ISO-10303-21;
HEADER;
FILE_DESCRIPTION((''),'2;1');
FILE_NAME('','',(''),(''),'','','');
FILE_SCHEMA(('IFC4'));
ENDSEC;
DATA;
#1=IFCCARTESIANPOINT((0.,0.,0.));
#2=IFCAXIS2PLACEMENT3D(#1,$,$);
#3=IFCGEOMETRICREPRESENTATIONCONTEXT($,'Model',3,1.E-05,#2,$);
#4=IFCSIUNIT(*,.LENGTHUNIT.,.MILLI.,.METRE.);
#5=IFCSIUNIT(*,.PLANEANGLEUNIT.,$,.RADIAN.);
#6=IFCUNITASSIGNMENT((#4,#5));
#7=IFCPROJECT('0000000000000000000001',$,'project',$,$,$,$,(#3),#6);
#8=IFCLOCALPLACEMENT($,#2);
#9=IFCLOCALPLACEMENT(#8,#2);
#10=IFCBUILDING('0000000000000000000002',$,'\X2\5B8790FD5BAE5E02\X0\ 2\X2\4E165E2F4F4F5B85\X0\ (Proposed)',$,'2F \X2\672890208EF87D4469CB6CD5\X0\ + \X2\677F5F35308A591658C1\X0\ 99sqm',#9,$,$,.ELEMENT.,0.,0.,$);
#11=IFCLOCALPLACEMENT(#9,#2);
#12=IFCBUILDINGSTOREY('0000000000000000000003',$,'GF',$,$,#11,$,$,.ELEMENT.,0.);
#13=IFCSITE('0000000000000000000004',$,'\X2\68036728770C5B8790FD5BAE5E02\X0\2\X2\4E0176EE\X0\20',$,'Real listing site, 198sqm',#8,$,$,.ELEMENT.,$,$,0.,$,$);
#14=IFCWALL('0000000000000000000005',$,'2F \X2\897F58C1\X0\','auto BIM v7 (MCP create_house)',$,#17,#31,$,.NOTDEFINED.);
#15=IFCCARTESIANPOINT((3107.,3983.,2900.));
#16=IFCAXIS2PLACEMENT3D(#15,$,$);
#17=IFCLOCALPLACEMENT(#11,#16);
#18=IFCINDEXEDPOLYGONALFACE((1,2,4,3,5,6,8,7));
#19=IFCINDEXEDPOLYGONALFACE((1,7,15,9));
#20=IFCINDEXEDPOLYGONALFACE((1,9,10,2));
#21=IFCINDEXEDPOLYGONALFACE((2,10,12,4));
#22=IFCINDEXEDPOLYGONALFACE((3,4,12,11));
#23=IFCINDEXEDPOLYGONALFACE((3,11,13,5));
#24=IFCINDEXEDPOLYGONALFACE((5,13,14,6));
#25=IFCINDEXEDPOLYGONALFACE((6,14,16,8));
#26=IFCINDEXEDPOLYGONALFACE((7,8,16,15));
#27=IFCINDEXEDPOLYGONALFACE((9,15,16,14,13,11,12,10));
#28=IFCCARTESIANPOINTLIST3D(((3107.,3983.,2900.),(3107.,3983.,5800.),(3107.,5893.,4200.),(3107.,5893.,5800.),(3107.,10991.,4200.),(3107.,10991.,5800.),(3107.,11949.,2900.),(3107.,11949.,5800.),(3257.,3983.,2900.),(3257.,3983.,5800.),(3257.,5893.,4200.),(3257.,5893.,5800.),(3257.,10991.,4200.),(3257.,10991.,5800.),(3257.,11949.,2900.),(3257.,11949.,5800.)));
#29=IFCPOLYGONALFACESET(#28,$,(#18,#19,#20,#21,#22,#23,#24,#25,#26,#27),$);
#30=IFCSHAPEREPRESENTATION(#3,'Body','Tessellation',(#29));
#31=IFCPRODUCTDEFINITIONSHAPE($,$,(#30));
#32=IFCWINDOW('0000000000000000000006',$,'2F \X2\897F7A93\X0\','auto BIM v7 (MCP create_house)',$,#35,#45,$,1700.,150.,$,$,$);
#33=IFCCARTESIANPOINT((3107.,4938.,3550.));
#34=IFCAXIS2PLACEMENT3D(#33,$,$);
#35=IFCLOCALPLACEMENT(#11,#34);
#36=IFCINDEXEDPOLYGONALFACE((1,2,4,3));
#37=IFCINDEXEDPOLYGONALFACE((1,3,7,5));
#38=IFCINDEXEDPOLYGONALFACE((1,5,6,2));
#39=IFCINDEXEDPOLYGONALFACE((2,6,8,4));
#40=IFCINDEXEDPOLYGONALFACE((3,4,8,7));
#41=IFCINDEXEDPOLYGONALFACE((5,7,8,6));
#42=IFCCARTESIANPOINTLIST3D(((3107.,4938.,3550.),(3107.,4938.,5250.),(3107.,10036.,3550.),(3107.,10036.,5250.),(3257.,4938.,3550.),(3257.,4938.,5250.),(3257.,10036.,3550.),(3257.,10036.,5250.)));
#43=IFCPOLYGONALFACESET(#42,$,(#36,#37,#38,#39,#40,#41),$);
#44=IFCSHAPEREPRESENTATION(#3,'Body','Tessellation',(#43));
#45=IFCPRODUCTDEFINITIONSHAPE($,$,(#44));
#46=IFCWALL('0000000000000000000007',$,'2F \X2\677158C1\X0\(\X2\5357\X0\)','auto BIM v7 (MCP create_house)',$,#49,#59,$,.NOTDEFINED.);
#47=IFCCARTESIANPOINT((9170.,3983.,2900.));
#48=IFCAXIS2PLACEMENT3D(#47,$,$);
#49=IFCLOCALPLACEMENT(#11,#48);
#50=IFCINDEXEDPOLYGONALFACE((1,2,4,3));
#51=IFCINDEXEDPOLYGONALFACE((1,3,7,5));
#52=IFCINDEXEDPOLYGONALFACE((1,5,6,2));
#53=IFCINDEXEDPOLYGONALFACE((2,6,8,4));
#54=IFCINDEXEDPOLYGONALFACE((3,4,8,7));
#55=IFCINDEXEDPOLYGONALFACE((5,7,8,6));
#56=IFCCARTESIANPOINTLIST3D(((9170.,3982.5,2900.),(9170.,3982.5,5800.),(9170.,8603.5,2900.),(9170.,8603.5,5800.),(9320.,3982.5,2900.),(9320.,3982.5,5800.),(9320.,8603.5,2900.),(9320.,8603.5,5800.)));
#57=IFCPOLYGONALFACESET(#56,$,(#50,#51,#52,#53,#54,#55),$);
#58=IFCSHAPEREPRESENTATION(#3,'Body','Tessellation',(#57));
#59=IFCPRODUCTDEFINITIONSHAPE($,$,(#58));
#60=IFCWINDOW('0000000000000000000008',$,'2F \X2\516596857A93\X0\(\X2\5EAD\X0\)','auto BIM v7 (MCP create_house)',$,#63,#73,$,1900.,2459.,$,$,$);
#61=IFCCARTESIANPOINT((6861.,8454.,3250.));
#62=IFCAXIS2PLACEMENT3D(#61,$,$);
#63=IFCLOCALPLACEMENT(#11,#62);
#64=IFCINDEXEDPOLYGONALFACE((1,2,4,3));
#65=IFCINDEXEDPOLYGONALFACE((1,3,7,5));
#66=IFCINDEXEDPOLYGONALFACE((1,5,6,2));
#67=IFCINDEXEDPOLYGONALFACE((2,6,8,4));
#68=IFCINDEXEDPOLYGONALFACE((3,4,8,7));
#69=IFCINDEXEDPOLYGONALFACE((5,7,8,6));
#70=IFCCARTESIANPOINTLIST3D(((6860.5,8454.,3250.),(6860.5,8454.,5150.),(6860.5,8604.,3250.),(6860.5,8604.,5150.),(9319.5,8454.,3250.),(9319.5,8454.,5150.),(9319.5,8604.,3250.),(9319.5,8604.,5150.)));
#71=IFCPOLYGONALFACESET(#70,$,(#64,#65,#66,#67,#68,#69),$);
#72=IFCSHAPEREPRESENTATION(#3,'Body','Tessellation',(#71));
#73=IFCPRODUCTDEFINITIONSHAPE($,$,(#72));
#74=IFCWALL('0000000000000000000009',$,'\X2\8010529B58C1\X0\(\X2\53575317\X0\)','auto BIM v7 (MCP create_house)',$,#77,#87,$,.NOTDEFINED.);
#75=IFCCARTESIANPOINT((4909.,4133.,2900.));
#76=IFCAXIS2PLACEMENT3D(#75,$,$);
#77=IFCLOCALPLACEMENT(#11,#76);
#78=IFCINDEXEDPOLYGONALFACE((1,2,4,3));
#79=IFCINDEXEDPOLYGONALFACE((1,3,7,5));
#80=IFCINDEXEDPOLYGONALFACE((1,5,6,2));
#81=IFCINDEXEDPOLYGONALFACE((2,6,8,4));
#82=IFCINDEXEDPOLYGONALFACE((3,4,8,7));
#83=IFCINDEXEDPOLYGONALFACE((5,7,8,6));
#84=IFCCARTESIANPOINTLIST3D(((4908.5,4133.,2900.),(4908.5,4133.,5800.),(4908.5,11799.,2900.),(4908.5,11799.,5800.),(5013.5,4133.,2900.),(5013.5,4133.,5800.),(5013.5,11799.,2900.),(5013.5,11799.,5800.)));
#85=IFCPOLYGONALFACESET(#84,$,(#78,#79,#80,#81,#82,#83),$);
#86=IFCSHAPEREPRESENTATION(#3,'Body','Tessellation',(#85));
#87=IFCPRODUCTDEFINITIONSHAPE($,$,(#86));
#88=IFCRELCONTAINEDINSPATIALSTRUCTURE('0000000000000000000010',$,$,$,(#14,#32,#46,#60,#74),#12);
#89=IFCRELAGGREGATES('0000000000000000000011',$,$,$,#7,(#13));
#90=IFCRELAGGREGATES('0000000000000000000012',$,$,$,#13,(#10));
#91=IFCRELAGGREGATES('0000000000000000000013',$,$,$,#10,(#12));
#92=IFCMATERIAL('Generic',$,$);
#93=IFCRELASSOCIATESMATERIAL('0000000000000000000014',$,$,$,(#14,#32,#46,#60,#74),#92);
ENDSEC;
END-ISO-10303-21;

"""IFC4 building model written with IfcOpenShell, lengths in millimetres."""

from ifc_helpers import new_model, si_unit, frame, frame_2d, origin, place, context, project, spatial, rectangle, extrude, material, element, fill, save


model = new_model("IFC4")

# Units and contexts
model_context = context("Model", 3, precision=1e-05, world=origin())
ifc_project = project(units=[si_unit("LENGTHUNIT", "METRE", prefix="MILLI"), si_unit("PLANEANGLEUNIT", "RADIAN")], contexts=[model_context])

# Site, building, storey
site_placement = place(None, origin())
site = spatial("IfcSite", under=ifc_project, at=site_placement, Name="栃木県宇都宮市2丁目20", ObjectType="Real listing site, 198sqm", CompositionType="ELEMENT", RefElevation=0.0)
building_placement = place(site_placement, origin())
building = spatial("IfcBuilding", under=site, at=building_placement, Name="宇都宮市 2世帯住宅 (Proposed)", ObjectType="2F 木造軸組構法 + 板張り外壁 99sqm", CompositionType="ELEMENT", ElevationOfRefHeight=0.0, ElevationOfTerrain=0.0)
storey_placement = place(building_placement, origin())
storey = spatial("IfcBuildingStorey", under=building, at=storey_placement, Name="GF", CompositionType="ELEMENT", Elevation=0.0)

# Shared definitions
ifc_material = material(Name="Generic")

# Walls, openings, windows
wall_1_placement = place(storey_placement, frame((3107.0, 3983.0, 2900.0)))
wall_1 = element("IfcWall", 1, at=wall_1_placement, inside=storey, material=ifc_material, Name="2F 西壁", Description="auto BIM v7 (MCP create_house)", PredefinedType="NOTDEFINED", context=model_context, shape_type="SweptSolid", body=[
    extrude(rectangle(XDim=150.0, YDim=7966.0, at=frame_2d((75.0, 3983.0))), frame((3107.0, 3983.0, 2900.0)), (0.0, 0.0, 1.0), 2900.0),
])
opening_1_placement = place(storey_placement, frame((3107.0, 4938.0, 3550.0)))
opening_1 = element("IfcOpeningElement", 2, at=opening_1_placement, cuts=wall_1, PredefinedType="NOTDEFINED", context=model_context, shape_type="SweptSolid", body=[
    extrude(rectangle(XDim=150.0, YDim=5098.0, at=frame_2d((75.0, 2549.0))), frame((3107.0, 4938.0, 3550.0)), (0.0, 0.0, 1.0), 1700.0),
])
window_1_placement = place(storey_placement, frame((3107.0, 4938.0, 3550.0)))
window_1 = element("IfcWindow", 3, at=window_1_placement, inside=storey, material=ifc_material, Name="2F 西窓", Description="auto BIM v7 (MCP create_house)", OverallHeight=1700.0, OverallWidth=150.0, context=model_context, shape_type="SweptSolid", body=[
    extrude(rectangle(XDim=150.0, YDim=5098.0, at=frame_2d((75.0, 2549.0))), frame((3107.0, 4938.0, 3550.0)), (0.0, 0.0, 1.0), 1700.0),
])
fill(opening_1, window_1)
wall_2_placement = place(storey_placement, frame((9170.0, 3983.0, 2900.0)))
wall_2 = element("IfcWall", 4, at=wall_2_placement, inside=storey, material=ifc_material, Name="2F 東壁(南)", Description="auto BIM v7 (MCP create_house)", PredefinedType="NOTDEFINED", context=model_context, shape_type="SweptSolid", body=[
    extrude(rectangle(XDim=150.0, YDim=4621.0, at=frame_2d((75.0, 2310.0))), frame((9170.0, 3983.0, 2900.0)), (0.0, 0.0, 1.0), 2900.0),
])
opening_2_placement = place(storey_placement, frame((6861.0, 8454.0, 3250.0)))
opening_2 = element("IfcOpeningElement", 5, at=opening_2_placement, cuts=wall_2, PredefinedType="NOTDEFINED", context=model_context, shape_type="SweptSolid", body=[
    extrude(rectangle(XDim=2459.0, YDim=150.0, at=frame_2d((1229.0, 75.0))), frame((6861.0, 8454.0, 3250.0)), (0.0, 0.0, 1.0), 1900.0),
])
window_2_placement = place(storey_placement, frame((6861.0, 8454.0, 3250.0)))
window_2 = element("IfcWindow", 6, at=window_2_placement, inside=storey, material=ifc_material, Name="2F 入隅窓(庭)", Description="auto BIM v7 (MCP create_house)", OverallHeight=1900.0, OverallWidth=2459.0, context=model_context, shape_type="SweptSolid", body=[
    extrude(rectangle(XDim=2459.0, YDim=150.0, at=frame_2d((1229.0, 75.0))), frame((6861.0, 8454.0, 3250.0)), (0.0, 0.0, 1.0), 1900.0),
])
fill(opening_2, window_2)

# Wall
wall_3_placement = place(storey_placement, frame((4909.0, 4133.0, 2900.0)))
element("IfcWall", 7, at=wall_3_placement, inside=storey, material=ifc_material, Name="耐力壁(南北)", Description="auto BIM v7 (MCP create_house)", PredefinedType="NOTDEFINED", context=model_context, shape_type="SweptSolid", body=[
    extrude(rectangle(XDim=105.0, YDim=7666.0, at=frame_2d((52.0, 3833.0))), frame((4909.0, 4133.0, 2900.0)), (0.0, 0.0, 1.0), 2900.0),
])

save(model, "model.ifc")
